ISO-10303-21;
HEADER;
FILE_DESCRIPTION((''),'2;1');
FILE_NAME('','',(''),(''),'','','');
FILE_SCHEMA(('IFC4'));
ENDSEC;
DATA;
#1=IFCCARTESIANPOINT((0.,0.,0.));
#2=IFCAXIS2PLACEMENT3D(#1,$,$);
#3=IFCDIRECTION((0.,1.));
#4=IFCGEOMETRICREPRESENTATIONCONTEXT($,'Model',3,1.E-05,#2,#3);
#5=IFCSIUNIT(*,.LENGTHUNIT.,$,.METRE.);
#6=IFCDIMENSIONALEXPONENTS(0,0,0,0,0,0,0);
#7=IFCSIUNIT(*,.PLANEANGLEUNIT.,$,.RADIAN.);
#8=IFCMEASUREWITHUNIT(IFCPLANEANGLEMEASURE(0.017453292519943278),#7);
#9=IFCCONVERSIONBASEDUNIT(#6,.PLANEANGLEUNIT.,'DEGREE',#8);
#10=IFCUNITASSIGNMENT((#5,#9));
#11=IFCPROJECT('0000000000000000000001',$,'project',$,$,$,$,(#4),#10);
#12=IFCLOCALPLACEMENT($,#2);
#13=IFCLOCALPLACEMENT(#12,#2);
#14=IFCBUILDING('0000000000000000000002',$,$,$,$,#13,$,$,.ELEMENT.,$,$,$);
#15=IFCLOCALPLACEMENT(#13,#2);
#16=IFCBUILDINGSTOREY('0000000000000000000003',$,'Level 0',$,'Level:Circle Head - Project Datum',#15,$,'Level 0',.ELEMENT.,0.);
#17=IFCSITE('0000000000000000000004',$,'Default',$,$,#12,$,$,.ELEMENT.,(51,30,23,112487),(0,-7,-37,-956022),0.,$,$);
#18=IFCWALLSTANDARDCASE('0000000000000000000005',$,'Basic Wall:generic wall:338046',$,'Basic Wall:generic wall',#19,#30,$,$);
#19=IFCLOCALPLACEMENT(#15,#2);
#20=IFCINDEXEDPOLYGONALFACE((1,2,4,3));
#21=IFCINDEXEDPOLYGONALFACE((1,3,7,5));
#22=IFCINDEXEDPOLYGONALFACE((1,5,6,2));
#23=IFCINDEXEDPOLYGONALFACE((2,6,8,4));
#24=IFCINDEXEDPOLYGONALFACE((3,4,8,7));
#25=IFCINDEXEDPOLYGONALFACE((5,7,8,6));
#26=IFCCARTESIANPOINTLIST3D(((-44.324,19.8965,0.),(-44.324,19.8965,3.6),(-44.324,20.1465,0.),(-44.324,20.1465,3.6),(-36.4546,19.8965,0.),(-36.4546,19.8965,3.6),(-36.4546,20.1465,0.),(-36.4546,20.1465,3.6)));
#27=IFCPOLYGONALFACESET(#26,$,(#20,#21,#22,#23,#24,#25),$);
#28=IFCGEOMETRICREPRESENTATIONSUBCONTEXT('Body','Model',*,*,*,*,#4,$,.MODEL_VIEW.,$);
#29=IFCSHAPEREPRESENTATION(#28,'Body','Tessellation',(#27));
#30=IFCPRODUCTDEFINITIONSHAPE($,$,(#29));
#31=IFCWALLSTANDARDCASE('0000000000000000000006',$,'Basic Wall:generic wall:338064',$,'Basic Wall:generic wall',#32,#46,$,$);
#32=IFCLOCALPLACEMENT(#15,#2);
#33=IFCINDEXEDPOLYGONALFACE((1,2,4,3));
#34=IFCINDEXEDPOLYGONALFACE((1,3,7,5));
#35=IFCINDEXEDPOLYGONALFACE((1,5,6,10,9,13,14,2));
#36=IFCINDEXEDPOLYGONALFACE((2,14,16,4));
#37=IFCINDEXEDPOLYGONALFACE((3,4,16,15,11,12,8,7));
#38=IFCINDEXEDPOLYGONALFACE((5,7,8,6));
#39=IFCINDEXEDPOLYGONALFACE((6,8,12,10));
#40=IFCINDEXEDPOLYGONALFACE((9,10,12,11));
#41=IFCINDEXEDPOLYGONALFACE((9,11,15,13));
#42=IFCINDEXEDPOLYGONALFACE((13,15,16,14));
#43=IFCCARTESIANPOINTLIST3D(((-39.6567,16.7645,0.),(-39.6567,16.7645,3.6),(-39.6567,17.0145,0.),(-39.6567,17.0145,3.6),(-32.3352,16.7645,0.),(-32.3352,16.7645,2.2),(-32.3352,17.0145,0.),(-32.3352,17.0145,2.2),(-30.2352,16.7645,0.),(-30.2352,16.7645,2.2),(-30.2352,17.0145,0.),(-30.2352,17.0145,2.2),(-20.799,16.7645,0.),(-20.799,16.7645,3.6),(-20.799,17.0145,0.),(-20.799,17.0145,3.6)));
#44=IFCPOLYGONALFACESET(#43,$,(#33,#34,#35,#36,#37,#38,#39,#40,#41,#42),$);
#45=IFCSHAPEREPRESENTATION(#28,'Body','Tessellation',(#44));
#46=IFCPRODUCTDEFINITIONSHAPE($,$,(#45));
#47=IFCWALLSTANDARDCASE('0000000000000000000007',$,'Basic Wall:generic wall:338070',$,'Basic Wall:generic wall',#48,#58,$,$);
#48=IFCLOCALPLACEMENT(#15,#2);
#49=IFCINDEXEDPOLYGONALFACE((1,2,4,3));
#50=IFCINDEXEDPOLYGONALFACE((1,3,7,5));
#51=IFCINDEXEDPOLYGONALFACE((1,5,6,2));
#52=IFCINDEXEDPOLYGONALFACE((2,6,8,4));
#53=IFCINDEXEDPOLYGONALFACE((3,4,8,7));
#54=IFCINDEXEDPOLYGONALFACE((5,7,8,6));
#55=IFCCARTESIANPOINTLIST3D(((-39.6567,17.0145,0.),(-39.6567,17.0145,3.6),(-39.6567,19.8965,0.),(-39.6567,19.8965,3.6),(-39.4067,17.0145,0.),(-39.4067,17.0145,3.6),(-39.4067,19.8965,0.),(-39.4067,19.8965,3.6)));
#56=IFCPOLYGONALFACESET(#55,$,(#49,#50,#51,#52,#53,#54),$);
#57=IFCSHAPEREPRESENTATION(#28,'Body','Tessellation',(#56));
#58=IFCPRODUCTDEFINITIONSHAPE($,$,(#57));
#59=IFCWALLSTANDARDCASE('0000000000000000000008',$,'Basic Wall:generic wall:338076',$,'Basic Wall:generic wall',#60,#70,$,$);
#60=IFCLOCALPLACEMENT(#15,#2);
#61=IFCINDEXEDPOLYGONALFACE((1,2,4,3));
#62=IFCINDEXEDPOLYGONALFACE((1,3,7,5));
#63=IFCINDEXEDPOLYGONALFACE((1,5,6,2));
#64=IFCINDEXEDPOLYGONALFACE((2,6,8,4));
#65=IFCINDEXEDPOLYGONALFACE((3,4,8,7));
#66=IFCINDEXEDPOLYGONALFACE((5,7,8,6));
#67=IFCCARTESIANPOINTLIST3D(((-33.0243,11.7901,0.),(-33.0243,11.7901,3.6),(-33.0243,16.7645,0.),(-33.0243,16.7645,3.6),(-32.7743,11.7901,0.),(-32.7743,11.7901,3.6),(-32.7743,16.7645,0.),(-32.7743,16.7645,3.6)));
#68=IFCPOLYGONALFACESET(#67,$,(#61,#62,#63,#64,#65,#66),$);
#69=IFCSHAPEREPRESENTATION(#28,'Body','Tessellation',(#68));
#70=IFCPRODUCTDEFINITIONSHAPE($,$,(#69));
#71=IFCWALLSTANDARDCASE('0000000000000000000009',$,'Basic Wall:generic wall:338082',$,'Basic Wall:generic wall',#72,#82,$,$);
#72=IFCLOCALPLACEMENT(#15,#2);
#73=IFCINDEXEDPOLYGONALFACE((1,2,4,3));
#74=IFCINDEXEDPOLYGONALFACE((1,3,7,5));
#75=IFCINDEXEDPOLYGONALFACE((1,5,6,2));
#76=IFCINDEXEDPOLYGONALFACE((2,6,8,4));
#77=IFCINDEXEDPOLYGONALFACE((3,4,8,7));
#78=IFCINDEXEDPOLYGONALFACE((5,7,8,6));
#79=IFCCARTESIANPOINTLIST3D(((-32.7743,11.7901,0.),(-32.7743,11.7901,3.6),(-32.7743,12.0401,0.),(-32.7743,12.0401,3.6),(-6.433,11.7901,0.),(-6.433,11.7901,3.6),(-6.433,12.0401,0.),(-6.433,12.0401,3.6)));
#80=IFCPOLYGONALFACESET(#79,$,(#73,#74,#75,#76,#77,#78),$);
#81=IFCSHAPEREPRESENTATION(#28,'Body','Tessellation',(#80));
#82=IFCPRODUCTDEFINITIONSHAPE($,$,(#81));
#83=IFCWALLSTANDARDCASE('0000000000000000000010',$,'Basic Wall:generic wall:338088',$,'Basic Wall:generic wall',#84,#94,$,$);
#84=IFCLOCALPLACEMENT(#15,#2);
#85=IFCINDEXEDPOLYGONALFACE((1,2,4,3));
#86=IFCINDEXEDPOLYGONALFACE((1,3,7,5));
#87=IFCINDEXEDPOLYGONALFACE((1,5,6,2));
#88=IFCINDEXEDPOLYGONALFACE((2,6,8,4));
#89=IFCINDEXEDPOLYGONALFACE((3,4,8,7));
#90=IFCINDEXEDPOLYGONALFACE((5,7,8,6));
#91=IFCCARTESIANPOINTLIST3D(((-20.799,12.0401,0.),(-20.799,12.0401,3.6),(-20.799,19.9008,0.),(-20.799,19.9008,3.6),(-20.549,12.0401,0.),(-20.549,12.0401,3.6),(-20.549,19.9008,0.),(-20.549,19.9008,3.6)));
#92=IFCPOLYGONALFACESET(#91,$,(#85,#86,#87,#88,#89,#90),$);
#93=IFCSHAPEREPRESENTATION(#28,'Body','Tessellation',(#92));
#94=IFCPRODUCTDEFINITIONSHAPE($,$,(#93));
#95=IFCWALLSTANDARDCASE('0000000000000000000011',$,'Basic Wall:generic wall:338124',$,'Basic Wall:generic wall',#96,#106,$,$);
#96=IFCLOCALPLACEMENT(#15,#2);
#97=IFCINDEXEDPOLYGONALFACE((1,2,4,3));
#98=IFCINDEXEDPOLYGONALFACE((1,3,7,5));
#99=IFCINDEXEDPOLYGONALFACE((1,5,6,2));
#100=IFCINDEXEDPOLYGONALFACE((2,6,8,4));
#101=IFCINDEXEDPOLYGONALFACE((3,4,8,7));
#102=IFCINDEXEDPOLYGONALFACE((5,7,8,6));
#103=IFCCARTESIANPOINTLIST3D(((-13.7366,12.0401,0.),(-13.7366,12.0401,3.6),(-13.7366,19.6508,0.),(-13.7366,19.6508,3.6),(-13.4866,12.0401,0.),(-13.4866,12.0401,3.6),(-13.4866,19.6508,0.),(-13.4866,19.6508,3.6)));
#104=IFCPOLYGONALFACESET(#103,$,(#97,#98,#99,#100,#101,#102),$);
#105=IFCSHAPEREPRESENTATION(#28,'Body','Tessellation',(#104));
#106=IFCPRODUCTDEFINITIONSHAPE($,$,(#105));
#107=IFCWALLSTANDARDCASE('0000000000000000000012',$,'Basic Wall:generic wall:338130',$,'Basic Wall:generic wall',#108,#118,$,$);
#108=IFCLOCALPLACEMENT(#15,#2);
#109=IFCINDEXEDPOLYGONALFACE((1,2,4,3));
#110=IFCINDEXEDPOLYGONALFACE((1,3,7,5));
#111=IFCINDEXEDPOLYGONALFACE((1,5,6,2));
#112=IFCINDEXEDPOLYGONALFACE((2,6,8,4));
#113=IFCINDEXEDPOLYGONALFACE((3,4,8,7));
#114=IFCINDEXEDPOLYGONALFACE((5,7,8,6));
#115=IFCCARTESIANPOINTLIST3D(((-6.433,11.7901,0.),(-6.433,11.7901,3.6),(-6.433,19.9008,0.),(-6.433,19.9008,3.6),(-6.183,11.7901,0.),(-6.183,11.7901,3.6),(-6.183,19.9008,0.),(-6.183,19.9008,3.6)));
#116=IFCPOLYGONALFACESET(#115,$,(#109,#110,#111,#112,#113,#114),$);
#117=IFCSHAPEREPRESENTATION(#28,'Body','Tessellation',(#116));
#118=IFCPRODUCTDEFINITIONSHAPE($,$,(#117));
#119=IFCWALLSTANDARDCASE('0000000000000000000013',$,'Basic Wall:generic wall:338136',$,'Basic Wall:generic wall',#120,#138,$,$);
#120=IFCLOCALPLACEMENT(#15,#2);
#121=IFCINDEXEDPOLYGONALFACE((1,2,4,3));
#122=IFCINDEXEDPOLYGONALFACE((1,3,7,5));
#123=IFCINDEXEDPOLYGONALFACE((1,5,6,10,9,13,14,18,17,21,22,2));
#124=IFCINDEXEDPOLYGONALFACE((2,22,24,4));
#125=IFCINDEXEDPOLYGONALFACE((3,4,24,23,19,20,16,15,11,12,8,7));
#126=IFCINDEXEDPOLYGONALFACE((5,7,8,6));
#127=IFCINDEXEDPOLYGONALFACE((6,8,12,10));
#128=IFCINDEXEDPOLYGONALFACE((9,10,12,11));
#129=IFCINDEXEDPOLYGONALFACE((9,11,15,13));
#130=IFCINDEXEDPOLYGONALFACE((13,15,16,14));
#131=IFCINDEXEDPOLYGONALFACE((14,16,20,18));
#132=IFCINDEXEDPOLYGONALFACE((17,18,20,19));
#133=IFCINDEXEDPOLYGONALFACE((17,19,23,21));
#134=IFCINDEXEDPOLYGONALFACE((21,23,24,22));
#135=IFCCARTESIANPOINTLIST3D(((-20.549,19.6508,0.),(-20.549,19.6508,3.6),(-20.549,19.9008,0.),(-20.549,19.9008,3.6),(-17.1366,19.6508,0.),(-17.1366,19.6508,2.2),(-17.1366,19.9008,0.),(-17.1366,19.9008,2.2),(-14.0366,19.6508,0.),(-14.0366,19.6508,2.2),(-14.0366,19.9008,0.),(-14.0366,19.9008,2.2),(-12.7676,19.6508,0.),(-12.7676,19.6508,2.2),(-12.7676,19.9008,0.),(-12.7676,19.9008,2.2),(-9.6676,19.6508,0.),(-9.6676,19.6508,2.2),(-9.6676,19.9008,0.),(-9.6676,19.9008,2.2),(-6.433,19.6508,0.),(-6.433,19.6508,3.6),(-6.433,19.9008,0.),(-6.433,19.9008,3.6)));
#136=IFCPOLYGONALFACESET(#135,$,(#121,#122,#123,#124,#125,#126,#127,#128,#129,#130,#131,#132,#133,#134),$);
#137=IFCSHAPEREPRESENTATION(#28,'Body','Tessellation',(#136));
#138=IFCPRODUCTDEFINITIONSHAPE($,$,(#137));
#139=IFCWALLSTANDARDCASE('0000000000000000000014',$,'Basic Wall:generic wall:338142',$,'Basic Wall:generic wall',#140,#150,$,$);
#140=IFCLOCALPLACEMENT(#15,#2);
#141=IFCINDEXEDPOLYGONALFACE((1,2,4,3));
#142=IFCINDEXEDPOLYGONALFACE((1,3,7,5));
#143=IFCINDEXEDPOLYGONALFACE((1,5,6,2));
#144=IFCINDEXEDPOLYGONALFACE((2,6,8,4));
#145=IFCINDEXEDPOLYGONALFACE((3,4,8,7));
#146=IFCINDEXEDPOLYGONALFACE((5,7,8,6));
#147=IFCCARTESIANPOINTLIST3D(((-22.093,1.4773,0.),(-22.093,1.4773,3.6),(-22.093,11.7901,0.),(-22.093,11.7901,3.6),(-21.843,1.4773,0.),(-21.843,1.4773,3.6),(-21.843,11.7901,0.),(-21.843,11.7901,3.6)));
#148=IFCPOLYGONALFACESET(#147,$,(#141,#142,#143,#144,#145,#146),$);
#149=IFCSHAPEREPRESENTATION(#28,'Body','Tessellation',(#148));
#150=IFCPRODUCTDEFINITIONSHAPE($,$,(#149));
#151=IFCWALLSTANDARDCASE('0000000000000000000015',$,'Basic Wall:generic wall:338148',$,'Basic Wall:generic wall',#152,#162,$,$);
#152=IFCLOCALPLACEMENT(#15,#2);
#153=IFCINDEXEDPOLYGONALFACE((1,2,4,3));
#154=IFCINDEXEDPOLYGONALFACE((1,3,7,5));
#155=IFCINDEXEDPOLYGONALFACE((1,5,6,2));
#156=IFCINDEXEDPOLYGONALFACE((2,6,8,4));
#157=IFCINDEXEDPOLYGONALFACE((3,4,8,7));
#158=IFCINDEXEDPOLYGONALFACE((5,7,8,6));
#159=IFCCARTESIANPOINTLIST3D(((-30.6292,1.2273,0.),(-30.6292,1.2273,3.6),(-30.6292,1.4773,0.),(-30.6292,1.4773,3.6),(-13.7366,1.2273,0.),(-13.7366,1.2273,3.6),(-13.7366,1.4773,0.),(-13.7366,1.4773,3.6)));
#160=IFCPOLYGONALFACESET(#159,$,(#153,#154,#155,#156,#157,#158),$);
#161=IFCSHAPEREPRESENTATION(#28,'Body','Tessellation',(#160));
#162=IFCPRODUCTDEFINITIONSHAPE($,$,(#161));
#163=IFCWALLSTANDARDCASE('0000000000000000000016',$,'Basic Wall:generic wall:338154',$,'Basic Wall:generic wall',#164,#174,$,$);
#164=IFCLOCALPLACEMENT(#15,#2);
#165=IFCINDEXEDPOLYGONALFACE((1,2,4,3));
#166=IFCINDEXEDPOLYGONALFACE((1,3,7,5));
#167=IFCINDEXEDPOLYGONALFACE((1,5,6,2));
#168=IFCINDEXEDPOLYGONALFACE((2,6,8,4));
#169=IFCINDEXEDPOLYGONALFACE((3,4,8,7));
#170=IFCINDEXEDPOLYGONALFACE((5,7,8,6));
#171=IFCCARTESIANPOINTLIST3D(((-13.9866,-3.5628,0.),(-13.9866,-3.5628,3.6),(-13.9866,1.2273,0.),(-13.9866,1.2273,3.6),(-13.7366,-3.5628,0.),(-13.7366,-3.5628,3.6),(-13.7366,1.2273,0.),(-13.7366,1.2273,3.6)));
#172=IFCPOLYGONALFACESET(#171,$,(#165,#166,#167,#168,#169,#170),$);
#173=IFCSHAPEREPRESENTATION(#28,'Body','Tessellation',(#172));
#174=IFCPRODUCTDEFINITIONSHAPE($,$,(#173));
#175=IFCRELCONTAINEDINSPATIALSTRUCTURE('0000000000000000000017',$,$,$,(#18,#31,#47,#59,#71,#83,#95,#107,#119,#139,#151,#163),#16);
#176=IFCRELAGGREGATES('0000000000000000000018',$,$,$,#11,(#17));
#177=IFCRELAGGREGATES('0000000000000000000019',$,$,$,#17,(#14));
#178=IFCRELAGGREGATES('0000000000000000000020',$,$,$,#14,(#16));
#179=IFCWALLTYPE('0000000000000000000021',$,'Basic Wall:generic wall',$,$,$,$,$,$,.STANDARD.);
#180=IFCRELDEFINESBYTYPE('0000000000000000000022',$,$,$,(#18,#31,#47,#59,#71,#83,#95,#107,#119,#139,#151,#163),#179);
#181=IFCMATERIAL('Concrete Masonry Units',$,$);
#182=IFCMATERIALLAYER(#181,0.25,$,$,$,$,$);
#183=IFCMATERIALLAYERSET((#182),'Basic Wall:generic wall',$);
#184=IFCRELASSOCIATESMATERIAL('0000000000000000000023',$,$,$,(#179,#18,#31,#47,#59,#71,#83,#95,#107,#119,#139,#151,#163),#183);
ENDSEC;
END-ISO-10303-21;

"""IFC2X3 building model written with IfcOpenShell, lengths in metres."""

from ifc_helpers import new_model, entity, si_unit, converted_unit, direction, frame, frame_2d, origin, place, context, subcontext, project, spatial, rectangle, extrude, material, layer, layer_set, layer_usage, type_object, element, save


model = new_model("IFC2X3")

# Units and contexts
model_context = context("Model", 3, precision=1e-05, world=origin(), true_north=direction((0.0, 1.0)))
body_context = subcontext(model_context, "Body", "Model", "MODEL_VIEW")
ifc_project = project(units=[si_unit("LENGTHUNIT", "METRE"), converted_unit("PLANEANGLEUNIT", "DEGREE", entity("IfcPlaneAngleMeasure", 0.017453292519943278), si_unit("PLANEANGLEUNIT", "RADIAN"), dimensions=[0, 0, 0, 0, 0, 0, 0])], contexts=[model_context])

# Site, building, storey
site_placement = place(None, origin())
site = spatial("IfcSite", under=ifc_project, at=site_placement, Name="Default", CompositionType="ELEMENT", RefLatitude=(51, 30, 23, 112487), RefLongitude=(0, -7, -37, -956022), RefElevation=0.0)
building_placement = place(site_placement, origin())
building = spatial("IfcBuilding", under=site, at=building_placement, CompositionType="ELEMENT")
storey_placement = place(building_placement, origin())
storey = spatial("IfcBuildingStorey", under=building, at=storey_placement, Name="Level 0", ObjectType="Level:Circle Head - Project Datum", LongName="Level 0", CompositionType="ELEMENT", Elevation=0.0)

# Wall
ifc_material = material(Name="Concrete Masonry Units")
ifc_layer = layer(ifc_material, 0.25)
ifc_layer_set = layer_set([ifc_layer], Name="Basic Wall:generic wall")
ifc_layer_usage_1 = layer_usage(ifc_layer_set, "AXIS2", "NEGATIVE", 0.125)
wall_type = type_object("IfcWallType", Name="Basic Wall:generic wall", PredefinedType="STANDARD", material=ifc_layer_set)
wall_1_placement = place(storey_placement, frame((-44.324, 20.0215, 0.0)))
element("IfcWallStandardCase", 1, at=wall_1_placement, inside=storey, type_object=wall_type, material=ifc_layer_usage_1, Name="Basic Wall:generic wall:338046", ObjectType="Basic Wall:generic wall", context=body_context, shape_type="SweptSolid", body=[
    extrude(rectangle(XDim=7.8694, YDim=0.25, at=frame_2d((3.9347, 0.0), x_axis=(-1.0, 0.0))), origin(), (0.0, 0.0, 1.0), 3.6),
])

# Wall, opening
ifc_layer_usage_2 = layer_usage(ifc_layer_set, "AXIS2", "NEGATIVE", 0.125)
wall_2_placement = place(storey_placement, frame((-39.6567, 16.8895, 0.0)))
wall_2 = element("IfcWallStandardCase", 2, at=wall_2_placement, inside=storey, type_object=wall_type, material=ifc_layer_usage_2, Name="Basic Wall:generic wall:338064", ObjectType="Basic Wall:generic wall", context=body_context, shape_type="SweptSolid", body=[
    extrude(rectangle(XDim=18.8578, YDim=0.25, at=frame_2d((9.4289, 0.0), x_axis=(-1.0, 0.0))), origin(), (0.0, 0.0, 1.0), 3.6),
])
opening_1_placement = place(wall_2_placement, frame((9.4215, 0.125, 0.0)))
element("IfcOpeningElement", 3, at=opening_1_placement, cuts=wall_2, ObjectType="Opening", context=body_context, shape_type="SweptSolid", body=[
    extrude(rectangle(XDim=2.2, YDim=2.1, at=frame_2d((1.1, 1.05), x_axis=(1.0, 0.0))), frame((0.0, 0.0, 0.0), z_axis=(0.0, -1.0, 0.0), x_axis=(0.0, 0.0, 1.0)), (0.0, 0.0, 1.0), 0.25),
])

# Walls
ifc_layer_usage_3 = layer_usage(ifc_layer_set, "AXIS2", "NEGATIVE", 0.125)
wall_3_placement = place(storey_placement, frame((-39.5317, 19.8965, 0.0), z_axis=(0.0, 0.0, 1.0), x_axis=(0.0, -1.0, 0.0)))
element("IfcWallStandardCase", 4, at=wall_3_placement, inside=storey, type_object=wall_type, material=ifc_layer_usage_3, Name="Basic Wall:generic wall:338070", ObjectType="Basic Wall:generic wall", context=body_context, shape_type="SweptSolid", body=[
    extrude(rectangle(XDim=2.882, YDim=0.25, at=frame_2d((1.441, 0.0), x_axis=(-1.0, 0.0))), origin(), (0.0, 0.0, 1.0), 3.6),
])
ifc_layer_usage_4 = layer_usage(ifc_layer_set, "AXIS2", "NEGATIVE", 0.125)
wall_4_placement = place(storey_placement, frame((-32.8993, 16.7645, 0.0), z_axis=(0.0, 0.0, 1.0), x_axis=(0.0, -1.0, 0.0)))
element("IfcWallStandardCase", 5, at=wall_4_placement, inside=storey, type_object=wall_type, material=ifc_layer_usage_4, Name="Basic Wall:generic wall:338076", ObjectType="Basic Wall:generic wall", context=body_context, shape_type="SweptSolid", body=[
    extrude(rectangle(XDim=4.9744, YDim=0.25, at=frame_2d((2.4872, 0.0), x_axis=(-1.0, 0.0))), origin(), (0.0, 0.0, 1.0), 3.6),
])
ifc_layer_usage_5 = layer_usage(ifc_layer_set, "AXIS2", "NEGATIVE", 0.125)
wall_5_placement = place(storey_placement, frame((-32.7743, 11.9151, 0.0)))
element("IfcWallStandardCase", 6, at=wall_5_placement, inside=storey, type_object=wall_type, material=ifc_layer_usage_5, Name="Basic Wall:generic wall:338082", ObjectType="Basic Wall:generic wall", context=body_context, shape_type="SweptSolid", body=[
    extrude(rectangle(XDim=26.3413, YDim=0.25, at=frame_2d((13.1706, 0.0), x_axis=(-1.0, 0.0))), origin(), (0.0, 0.0, 1.0), 3.6),
])
ifc_layer_usage_6 = layer_usage(ifc_layer_set, "AXIS2", "NEGATIVE", 0.125)
wall_6_placement = place(storey_placement, frame((-20.674, 12.0401, 0.0), z_axis=(0.0, 0.0, 1.0), x_axis=(0.0, 1.0, 0.0)))
element("IfcWallStandardCase", 7, at=wall_6_placement, inside=storey, type_object=wall_type, material=ifc_layer_usage_6, Name="Basic Wall:generic wall:338088", ObjectType="Basic Wall:generic wall", context=body_context, shape_type="SweptSolid", body=[
    extrude(rectangle(XDim=7.8607, YDim=0.25, at=frame_2d((3.9304, 0.0), x_axis=(-1.0, 0.0))), origin(), (0.0, 0.0, 1.0), 3.6),
])
ifc_layer_usage_7 = layer_usage(ifc_layer_set, "AXIS2", "NEGATIVE", 0.125)
wall_7_placement = place(storey_placement, frame((-13.6116, 12.0401, 0.0), z_axis=(0.0, 0.0, 1.0), x_axis=(0.0, 1.0, 0.0)))
element("IfcWallStandardCase", 8, at=wall_7_placement, inside=storey, type_object=wall_type, material=ifc_layer_usage_7, Name="Basic Wall:generic wall:338124", ObjectType="Basic Wall:generic wall", context=body_context, shape_type="SweptSolid", body=[
    extrude(rectangle(XDim=7.6107, YDim=0.25, at=frame_2d((3.8054, 0.0), x_axis=(-1.0, 0.0))), origin(), (0.0, 0.0, 1.0), 3.6),
])
ifc_layer_usage_8 = layer_usage(ifc_layer_set, "AXIS2", "NEGATIVE", 0.125)
wall_8_placement = place(storey_placement, frame((-6.308, 19.9008, 0.0), z_axis=(0.0, 0.0, 1.0), x_axis=(0.0, -1.0, 0.0)))
element("IfcWallStandardCase", 9, at=wall_8_placement, inside=storey, type_object=wall_type, material=ifc_layer_usage_8, Name="Basic Wall:generic wall:338130", ObjectType="Basic Wall:generic wall", context=body_context, shape_type="SweptSolid", body=[
    extrude(rectangle(XDim=8.1107, YDim=0.25, at=frame_2d((4.0554, 0.0), x_axis=(-1.0, 0.0))), origin(), (0.0, 0.0, 1.0), 3.6),
])

# Wall, openings
ifc_layer_usage_9 = layer_usage(ifc_layer_set, "AXIS2", "NEGATIVE", 0.125)
wall_9_placement = place(storey_placement, frame((-20.549, 19.7758, 0.0)))
wall_9 = element("IfcWallStandardCase", 10, at=wall_9_placement, inside=storey, type_object=wall_type, material=ifc_layer_usage_9, Name="Basic Wall:generic wall:338136", ObjectType="Basic Wall:generic wall", context=body_context, shape_type="SweptSolid", body=[
    extrude(rectangle(XDim=14.116, YDim=0.25, at=frame_2d((7.058, 0.0), x_axis=(-1.0, 0.0))), origin(), (0.0, 0.0, 1.0), 3.6),
])
opening_2_placement = place(wall_9_placement, frame((6.5124, 0.125, 0.0)))
element("IfcOpeningElement", 11, at=opening_2_placement, cuts=wall_9, ObjectType="Opening", context=body_context, shape_type="SweptSolid", body=[
    extrude(rectangle(XDim=2.2, YDim=3.1, at=frame_2d((1.1, 1.55), x_axis=(1.0, 0.0))), frame((0.0, 0.0, 0.0), z_axis=(0.0, -1.0, 0.0), x_axis=(0.0, 0.0, 1.0)), (0.0, 0.0, 1.0), 0.25),
])
opening_3_placement = place(wall_9_placement, frame((10.8814, 0.125, 0.0)))
element("IfcOpeningElement", 12, at=opening_3_placement, cuts=wall_9, ObjectType="Opening", context=body_context, shape_type="SweptSolid", body=[
    extrude(rectangle(XDim=2.2, YDim=3.1, at=frame_2d((1.1, 1.55), x_axis=(1.0, 0.0))), frame((0.0, 0.0, 0.0), z_axis=(0.0, -1.0, 0.0), x_axis=(0.0, 0.0, 1.0)), (0.0, 0.0, 1.0), 0.25),
])

# Walls
ifc_layer_usage_10 = layer_usage(ifc_layer_set, "AXIS2", "NEGATIVE", 0.125)
wall_10_placement = place(storey_placement, frame((-21.968, 11.7901, 0.0), z_axis=(0.0, 0.0, 1.0), x_axis=(0.0, -1.0, 0.0)))
element("IfcWallStandardCase", 13, at=wall_10_placement, inside=storey, type_object=wall_type, material=ifc_layer_usage_10, Name="Basic Wall:generic wall:338142", ObjectType="Basic Wall:generic wall", context=body_context, shape_type="SweptSolid", body=[
    extrude(rectangle(XDim=10.3128, YDim=0.25, at=frame_2d((5.1564, 0.0), x_axis=(-1.0, 0.0))), origin(), (0.0, 0.0, 1.0), 3.6),
])
ifc_layer_usage_11 = layer_usage(ifc_layer_set, "AXIS2", "NEGATIVE", 0.125)
wall_11_placement = place(storey_placement, frame((-30.6292, 1.3523, 0.0)))
element("IfcWallStandardCase", 14, at=wall_11_placement, inside=storey, type_object=wall_type, material=ifc_layer_usage_11, Name="Basic Wall:generic wall:338148", ObjectType="Basic Wall:generic wall", context=body_context, shape_type="SweptSolid", body=[
    extrude(rectangle(XDim=16.8926, YDim=0.25, at=frame_2d((8.4463, 0.0), x_axis=(-1.0, 0.0))), origin(), (0.0, 0.0, 1.0), 3.6),
])
ifc_layer_usage_12 = layer_usage(ifc_layer_set, "AXIS2", "NEGATIVE", 0.125)
wall_12_placement = place(storey_placement, frame((-13.8616, 1.2273, 0.0), z_axis=(0.0, 0.0, 1.0), x_axis=(0.0, -1.0, 0.0)))
element("IfcWallStandardCase", 15, at=wall_12_placement, inside=storey, type_object=wall_type, material=ifc_layer_usage_12, Name="Basic Wall:generic wall:338154", ObjectType="Basic Wall:generic wall", context=body_context, shape_type="SweptSolid", body=[
    extrude(rectangle(XDim=4.7901, YDim=0.25, at=frame_2d((2.3951, 0.0), x_axis=(-1.0, 0.0))), origin(), (0.0, 0.0, 1.0), 3.6),
])

save(model, "model.ifc")
